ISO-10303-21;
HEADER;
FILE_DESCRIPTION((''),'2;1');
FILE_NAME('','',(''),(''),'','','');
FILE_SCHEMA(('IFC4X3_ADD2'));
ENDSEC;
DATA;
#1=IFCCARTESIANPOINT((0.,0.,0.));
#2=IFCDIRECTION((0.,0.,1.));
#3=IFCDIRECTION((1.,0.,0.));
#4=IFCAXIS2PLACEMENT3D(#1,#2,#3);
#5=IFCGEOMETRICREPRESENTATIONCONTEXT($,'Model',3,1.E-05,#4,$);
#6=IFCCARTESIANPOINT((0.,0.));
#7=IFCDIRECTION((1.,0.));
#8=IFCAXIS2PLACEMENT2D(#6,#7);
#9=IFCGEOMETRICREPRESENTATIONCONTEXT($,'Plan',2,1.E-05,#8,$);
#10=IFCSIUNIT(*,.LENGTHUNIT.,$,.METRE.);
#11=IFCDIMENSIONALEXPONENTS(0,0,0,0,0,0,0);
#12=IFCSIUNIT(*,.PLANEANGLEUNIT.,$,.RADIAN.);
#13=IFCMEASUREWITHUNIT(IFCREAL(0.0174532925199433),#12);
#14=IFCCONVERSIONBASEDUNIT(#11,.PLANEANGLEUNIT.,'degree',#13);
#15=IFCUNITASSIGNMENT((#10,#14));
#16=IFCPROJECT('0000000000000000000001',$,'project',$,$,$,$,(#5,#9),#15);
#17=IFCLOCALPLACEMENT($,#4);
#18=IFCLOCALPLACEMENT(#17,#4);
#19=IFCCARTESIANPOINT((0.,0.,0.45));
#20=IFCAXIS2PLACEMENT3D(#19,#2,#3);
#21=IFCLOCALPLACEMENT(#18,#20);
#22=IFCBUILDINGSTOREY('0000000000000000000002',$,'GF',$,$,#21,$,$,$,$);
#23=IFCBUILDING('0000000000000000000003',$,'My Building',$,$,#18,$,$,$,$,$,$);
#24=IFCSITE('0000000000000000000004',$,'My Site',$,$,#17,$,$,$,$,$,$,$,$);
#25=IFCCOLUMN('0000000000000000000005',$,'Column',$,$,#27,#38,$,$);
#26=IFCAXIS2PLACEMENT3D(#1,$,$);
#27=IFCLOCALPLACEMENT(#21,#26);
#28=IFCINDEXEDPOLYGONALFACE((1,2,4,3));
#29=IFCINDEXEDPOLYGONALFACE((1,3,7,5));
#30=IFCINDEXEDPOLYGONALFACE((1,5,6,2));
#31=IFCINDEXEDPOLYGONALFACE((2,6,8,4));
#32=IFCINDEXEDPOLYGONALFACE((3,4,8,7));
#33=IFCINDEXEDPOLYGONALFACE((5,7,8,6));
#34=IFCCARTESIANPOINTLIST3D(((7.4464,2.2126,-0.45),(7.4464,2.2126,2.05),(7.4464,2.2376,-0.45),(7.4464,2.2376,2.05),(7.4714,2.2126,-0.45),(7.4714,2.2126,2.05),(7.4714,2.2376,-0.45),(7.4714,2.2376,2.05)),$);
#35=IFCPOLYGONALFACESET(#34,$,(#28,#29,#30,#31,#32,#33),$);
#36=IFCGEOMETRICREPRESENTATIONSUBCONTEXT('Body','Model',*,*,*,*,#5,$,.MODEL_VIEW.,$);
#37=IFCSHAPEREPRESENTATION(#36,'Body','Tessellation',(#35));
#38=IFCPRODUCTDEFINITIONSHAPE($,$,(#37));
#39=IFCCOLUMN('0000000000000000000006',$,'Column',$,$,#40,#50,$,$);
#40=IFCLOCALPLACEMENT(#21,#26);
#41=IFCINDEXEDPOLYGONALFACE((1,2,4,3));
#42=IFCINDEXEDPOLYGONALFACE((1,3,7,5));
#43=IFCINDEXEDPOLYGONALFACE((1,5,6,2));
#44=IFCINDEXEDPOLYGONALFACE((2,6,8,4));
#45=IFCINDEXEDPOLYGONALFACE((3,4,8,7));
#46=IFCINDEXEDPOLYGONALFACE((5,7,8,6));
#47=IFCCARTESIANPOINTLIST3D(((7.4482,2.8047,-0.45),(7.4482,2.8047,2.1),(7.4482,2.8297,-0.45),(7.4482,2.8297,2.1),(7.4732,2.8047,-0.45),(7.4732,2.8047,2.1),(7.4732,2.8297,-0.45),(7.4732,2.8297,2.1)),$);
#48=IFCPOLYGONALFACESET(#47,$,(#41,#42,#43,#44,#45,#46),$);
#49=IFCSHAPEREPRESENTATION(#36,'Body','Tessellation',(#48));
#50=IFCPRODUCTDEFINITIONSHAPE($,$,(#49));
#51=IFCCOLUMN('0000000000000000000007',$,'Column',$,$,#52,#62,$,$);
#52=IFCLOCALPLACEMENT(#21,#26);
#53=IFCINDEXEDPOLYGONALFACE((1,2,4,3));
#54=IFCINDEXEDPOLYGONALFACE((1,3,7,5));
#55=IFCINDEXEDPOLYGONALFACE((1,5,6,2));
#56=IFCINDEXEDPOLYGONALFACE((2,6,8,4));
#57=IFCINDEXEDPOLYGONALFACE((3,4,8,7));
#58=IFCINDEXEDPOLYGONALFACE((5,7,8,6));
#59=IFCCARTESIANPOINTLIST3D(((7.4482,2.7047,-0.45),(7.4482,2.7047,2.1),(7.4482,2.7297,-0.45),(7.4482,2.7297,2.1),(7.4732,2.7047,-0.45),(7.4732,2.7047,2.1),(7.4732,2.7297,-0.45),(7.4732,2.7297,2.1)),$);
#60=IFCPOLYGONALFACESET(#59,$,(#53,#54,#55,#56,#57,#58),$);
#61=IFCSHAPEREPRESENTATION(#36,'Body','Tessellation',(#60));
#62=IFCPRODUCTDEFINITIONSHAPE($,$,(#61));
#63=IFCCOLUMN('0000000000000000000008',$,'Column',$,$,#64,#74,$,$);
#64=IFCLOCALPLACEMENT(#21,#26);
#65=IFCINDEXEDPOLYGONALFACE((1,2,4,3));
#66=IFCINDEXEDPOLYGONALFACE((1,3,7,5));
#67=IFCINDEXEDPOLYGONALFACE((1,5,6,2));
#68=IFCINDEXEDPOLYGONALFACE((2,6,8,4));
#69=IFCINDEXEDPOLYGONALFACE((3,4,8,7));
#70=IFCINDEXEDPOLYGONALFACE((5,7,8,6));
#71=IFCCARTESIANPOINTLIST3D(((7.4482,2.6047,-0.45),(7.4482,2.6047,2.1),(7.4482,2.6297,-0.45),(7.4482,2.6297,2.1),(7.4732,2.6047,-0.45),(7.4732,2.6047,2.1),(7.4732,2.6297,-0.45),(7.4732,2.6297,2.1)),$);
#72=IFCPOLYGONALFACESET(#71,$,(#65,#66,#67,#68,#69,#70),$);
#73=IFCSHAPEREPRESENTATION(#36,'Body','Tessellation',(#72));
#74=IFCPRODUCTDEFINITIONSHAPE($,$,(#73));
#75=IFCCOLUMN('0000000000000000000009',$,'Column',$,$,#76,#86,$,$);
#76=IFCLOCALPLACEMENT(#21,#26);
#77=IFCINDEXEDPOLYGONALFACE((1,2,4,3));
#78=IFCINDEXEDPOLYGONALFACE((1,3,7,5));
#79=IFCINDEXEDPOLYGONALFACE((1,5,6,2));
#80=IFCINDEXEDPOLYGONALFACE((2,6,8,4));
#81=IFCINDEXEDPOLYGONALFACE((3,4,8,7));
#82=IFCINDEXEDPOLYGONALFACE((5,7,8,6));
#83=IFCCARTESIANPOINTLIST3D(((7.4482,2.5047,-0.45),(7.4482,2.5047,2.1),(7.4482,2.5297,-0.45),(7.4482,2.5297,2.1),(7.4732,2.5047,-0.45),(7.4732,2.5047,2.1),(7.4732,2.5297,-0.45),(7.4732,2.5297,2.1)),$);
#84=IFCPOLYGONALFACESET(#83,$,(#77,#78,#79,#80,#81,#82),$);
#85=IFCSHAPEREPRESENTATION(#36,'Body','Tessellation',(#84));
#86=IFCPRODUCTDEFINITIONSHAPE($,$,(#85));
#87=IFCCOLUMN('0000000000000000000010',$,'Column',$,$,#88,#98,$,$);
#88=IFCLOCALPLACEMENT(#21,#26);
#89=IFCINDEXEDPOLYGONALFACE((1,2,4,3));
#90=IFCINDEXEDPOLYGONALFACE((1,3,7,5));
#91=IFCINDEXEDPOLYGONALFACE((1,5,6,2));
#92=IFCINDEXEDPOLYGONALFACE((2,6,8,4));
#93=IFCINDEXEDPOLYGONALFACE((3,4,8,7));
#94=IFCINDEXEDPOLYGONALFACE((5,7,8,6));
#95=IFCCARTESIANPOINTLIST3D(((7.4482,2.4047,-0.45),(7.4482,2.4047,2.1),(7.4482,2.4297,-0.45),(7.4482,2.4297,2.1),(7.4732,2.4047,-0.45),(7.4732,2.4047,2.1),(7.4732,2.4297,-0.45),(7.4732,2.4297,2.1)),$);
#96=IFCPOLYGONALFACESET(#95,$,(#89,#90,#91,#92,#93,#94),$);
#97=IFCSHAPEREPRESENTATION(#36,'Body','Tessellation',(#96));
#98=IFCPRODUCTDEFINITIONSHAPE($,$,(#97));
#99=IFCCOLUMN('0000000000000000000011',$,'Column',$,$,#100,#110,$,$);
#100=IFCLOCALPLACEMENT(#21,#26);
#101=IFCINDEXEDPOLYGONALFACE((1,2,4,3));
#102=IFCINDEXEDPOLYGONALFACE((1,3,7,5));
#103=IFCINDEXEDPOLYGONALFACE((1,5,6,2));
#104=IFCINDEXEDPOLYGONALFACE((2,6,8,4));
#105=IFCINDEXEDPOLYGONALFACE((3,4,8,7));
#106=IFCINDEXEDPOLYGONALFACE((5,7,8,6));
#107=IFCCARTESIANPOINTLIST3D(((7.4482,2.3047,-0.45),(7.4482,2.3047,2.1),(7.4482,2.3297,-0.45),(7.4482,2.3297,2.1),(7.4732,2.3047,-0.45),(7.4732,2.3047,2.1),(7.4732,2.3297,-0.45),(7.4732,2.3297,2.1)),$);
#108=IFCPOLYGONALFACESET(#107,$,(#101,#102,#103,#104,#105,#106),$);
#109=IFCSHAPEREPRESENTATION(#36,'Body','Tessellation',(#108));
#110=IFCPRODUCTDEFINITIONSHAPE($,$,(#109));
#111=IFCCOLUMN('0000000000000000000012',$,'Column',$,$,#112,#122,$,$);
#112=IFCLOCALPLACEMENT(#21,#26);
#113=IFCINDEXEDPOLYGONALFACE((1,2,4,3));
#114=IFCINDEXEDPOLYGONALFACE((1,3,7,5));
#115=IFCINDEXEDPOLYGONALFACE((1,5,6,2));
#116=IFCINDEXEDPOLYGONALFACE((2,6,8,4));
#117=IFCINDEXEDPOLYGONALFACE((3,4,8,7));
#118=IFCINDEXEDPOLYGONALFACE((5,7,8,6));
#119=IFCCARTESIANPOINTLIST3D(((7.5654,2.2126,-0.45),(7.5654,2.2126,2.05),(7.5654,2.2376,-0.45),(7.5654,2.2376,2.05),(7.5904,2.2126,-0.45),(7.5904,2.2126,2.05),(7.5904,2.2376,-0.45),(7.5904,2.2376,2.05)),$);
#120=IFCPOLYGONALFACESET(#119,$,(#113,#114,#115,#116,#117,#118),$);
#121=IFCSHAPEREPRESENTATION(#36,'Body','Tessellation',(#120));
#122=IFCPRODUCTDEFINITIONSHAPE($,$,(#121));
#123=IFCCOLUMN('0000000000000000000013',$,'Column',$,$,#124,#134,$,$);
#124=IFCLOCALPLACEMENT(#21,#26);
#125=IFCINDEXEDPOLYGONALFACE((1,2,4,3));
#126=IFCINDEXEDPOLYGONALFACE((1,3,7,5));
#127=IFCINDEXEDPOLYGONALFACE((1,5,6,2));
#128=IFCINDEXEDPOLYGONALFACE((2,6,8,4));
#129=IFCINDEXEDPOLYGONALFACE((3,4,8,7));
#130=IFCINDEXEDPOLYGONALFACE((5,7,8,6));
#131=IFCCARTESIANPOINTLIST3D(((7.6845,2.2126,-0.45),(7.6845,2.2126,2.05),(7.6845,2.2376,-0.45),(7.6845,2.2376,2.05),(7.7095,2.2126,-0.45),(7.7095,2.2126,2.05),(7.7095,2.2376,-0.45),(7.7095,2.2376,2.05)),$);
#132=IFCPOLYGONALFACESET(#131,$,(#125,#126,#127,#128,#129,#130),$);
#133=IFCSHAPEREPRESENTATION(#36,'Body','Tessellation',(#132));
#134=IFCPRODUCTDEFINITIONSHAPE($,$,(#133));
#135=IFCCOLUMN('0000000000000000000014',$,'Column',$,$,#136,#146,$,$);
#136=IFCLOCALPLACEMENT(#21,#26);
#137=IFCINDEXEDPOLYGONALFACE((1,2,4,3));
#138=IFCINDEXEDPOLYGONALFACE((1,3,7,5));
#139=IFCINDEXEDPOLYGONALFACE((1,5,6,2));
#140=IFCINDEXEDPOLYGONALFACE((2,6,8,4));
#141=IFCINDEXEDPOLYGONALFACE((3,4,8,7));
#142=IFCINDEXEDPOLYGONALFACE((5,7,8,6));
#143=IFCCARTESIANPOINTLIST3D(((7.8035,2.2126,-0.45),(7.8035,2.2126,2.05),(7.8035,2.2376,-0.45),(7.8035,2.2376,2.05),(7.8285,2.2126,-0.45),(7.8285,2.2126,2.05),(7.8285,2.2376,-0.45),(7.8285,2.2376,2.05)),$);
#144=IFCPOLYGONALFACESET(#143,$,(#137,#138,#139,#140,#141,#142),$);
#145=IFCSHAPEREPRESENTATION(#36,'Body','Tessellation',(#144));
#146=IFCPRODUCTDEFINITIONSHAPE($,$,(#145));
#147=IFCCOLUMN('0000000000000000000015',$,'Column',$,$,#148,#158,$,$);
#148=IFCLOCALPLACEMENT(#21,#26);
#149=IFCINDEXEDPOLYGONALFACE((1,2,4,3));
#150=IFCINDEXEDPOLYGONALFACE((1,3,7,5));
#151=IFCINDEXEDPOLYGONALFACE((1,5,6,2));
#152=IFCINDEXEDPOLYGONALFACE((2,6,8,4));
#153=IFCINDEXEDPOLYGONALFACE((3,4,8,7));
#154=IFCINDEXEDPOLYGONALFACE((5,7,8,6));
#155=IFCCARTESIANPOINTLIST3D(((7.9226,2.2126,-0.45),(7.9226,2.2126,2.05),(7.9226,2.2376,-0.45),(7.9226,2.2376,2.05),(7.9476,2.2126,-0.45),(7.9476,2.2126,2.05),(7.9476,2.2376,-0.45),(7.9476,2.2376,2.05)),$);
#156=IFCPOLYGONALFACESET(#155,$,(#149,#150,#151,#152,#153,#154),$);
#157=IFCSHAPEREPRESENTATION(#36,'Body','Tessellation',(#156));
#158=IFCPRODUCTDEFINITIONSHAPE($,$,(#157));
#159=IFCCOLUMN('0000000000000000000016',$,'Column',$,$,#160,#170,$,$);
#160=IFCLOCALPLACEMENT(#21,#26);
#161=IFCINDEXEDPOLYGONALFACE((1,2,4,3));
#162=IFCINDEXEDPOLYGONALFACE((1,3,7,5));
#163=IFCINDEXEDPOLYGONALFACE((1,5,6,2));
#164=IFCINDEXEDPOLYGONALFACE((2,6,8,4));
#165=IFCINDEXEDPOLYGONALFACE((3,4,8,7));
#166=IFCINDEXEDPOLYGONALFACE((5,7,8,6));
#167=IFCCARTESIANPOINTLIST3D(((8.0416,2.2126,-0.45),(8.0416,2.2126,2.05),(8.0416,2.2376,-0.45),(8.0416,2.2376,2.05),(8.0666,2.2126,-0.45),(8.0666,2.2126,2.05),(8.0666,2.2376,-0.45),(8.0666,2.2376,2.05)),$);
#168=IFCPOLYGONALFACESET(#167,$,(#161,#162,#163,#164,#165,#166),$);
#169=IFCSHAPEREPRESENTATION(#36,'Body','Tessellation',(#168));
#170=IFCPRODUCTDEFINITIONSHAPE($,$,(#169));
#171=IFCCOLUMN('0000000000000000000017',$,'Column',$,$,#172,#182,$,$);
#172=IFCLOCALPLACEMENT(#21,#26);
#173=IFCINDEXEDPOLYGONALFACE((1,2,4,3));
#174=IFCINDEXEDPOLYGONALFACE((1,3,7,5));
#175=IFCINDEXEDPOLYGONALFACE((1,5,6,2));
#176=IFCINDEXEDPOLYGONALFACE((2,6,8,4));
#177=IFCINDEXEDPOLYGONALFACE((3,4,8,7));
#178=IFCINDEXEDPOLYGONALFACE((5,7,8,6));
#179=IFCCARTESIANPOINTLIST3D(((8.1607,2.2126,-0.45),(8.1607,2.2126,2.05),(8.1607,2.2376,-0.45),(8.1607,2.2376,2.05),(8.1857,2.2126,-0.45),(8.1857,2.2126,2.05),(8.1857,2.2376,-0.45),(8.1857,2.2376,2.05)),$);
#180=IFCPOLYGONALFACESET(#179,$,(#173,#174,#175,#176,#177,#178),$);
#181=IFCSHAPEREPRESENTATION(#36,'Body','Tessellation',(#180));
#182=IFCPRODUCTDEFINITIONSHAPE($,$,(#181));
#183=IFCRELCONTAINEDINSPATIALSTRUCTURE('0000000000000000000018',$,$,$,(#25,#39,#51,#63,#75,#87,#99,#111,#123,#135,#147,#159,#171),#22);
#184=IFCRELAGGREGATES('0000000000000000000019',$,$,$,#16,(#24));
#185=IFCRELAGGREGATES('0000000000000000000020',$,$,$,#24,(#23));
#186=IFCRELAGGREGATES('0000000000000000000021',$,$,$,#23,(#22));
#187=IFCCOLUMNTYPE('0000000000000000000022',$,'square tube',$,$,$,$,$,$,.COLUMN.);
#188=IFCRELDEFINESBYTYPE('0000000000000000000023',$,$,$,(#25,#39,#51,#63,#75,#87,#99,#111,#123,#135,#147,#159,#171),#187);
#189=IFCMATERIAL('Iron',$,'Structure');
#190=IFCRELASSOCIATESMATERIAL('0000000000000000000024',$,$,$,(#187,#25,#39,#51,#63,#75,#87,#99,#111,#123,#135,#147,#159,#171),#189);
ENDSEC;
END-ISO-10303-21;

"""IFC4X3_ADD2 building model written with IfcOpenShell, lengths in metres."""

from ifc_helpers import new_model, entity, si_unit, converted_unit, frame, origin_with_axes, origin_2d_with_axis, place, context, subcontext, project, spatial, indexed_curve, outline, extrude, material, material_profile, profile_set, profile_usage, type_object, element, save


model = new_model("IFC4X3_ADD2")

# Units and contexts
model_context = context("Model", 3, precision=1e-05, world=origin_with_axes())
plan_context = context("Plan", 2, precision=1e-05, world=origin_2d_with_axis())
body_context = subcontext(model_context, "Body", "Model", "MODEL_VIEW")
ifc_project = project(units=[si_unit("LENGTHUNIT", "METRE"), converted_unit("PLANEANGLEUNIT", "degree", entity("IfcReal", 0.0174532925199433), si_unit("PLANEANGLEUNIT", "RADIAN"), dimensions=[0, 0, 0, 0, 0, 0, 0])], contexts=[model_context, plan_context])

# Site, building, storey
site_placement = place(None, origin_with_axes())
site = spatial("IfcSite", under=ifc_project, at=site_placement, Name="My Site")
building_placement = place(site_placement, origin_with_axes())
building = spatial("IfcBuilding", under=site, at=building_placement, Name="My Building")
storey_placement = place(building_placement, frame((0.0, 0.0, 0.45), z_axis=(0.0, 0.0, 1.0), x_axis=(1.0, 0.0, 0.0)))
storey = spatial("IfcBuildingStorey", under=building, at=storey_placement, Name="GF")

# Columns
ifc_material_1 = material(Name="Iron", Category="Structure")
ifc_material_profile = material_profile(ifc_material_1, outline(indexed_curve([(-0.0125, -0.0125), (0.0125, -0.0125), (0.0125, 0.0125), (-0.0125, 0.0125), (-0.0125, -0.0125)])))
ifc_profile_set = profile_set([ifc_material_profile])
ifc_profile_usage_1 = profile_usage(ifc_profile_set, cardinal=5)
column_type = type_object("IfcColumnType", Name="square tube", PredefinedType="COLUMN", material=ifc_profile_set)
column_1_placement = place(storey_placement, frame((7.4589, 2.2251, -0.45), z_axis=(0.0, 0.0, 1.0), x_axis=(1.0, 0.0, 0.0)))
element("IfcColumn", 1, at=column_1_placement, inside=storey, type_object=column_type, material=ifc_profile_usage_1, Name="Column", context=body_context, shape_type="SweptSolid", body=[
    extrude(outline(indexed_curve([(-0.0125, -0.0125), (0.0125, -0.0125), (0.0125, 0.0125), (-0.0125, 0.0125), (-0.0125, -0.0125)])), origin_with_axes(), (0.0, 0.0, 1.0), 2.5),
])
ifc_profile_usage_2 = profile_usage(ifc_profile_set, cardinal=5)
column_2_placement = place(storey_placement, frame((7.4607, 2.8172, -0.45), z_axis=(0.0, 0.0, 1.0), x_axis=(0.0, -1.0, 0.0)))
element("IfcColumn", 2, at=column_2_placement, inside=storey, type_object=column_type, material=ifc_profile_usage_2, Name="Column", context=body_context, shape_type="SweptSolid", body=[
    extrude(outline(indexed_curve([(-0.0125, -0.0125), (0.0125, -0.0125), (0.0125, 0.0125), (-0.0125, 0.0125), (-0.0125, -0.0125)])), origin_with_axes(), (0.0, 0.0, 1.0), 2.55),
])
ifc_profile_usage_3 = profile_usage(ifc_profile_set, cardinal=5)
column_3_placement = place(storey_placement, frame((7.4607, 2.7172, -0.45), z_axis=(0.0, 0.0, 1.0), x_axis=(0.0, -1.0, 0.0)))
element("IfcColumn", 3, at=column_3_placement, inside=storey, type_object=column_type, material=ifc_profile_usage_3, Name="Column", context=body_context, shape_type="SweptSolid", body=[
    extrude(outline(indexed_curve([(-0.0125, -0.0125), (0.0125, -0.0125), (0.0125, 0.0125), (-0.0125, 0.0125), (-0.0125, -0.0125)])), origin_with_axes(), (0.0, 0.0, 1.0), 2.55),
])
ifc_profile_usage_4 = profile_usage(ifc_profile_set, cardinal=5)
column_4_placement = place(storey_placement, frame((7.4607, 2.6172, -0.45), z_axis=(0.0, 0.0, 1.0), x_axis=(0.0, -1.0, 0.0)))
element("IfcColumn", 4, at=column_4_placement, inside=storey, type_object=column_type, material=ifc_profile_usage_4, Name="Column", context=body_context, shape_type="SweptSolid", body=[
    extrude(outline(indexed_curve([(-0.0125, -0.0125), (0.0125, -0.0125), (0.0125, 0.0125), (-0.0125, 0.0125), (-0.0125, -0.0125)])), origin_with_axes(), (0.0, 0.0, 1.0), 2.55),
])
ifc_profile_usage_5 = profile_usage(ifc_profile_set, cardinal=5)
column_5_placement = place(storey_placement, frame((7.4607, 2.5172, -0.45), z_axis=(0.0, 0.0, 1.0), x_axis=(0.0, -1.0, 0.0)))
element("IfcColumn", 5, at=column_5_placement, inside=storey, type_object=column_type, material=ifc_profile_usage_5, Name="Column", context=body_context, shape_type="SweptSolid", body=[
    extrude(outline(indexed_curve([(-0.0125, -0.0125), (0.0125, -0.0125), (0.0125, 0.0125), (-0.0125, 0.0125), (-0.0125, -0.0125)])), origin_with_axes(), (0.0, 0.0, 1.0), 2.55),
])
ifc_profile_usage_6 = profile_usage(ifc_profile_set, cardinal=5)
column_6_placement = place(storey_placement, frame((7.4607, 2.4172, -0.45), z_axis=(0.0, 0.0, 1.0), x_axis=(0.0, -1.0, 0.0)))
element("IfcColumn", 6, at=column_6_placement, inside=storey, type_object=column_type, material=ifc_profile_usage_6, Name="Column", context=body_context, shape_type="SweptSolid", body=[
    extrude(outline(indexed_curve([(-0.0125, -0.0125), (0.0125, -0.0125), (0.0125, 0.0125), (-0.0125, 0.0125), (-0.0125, -0.0125)])), origin_with_axes(), (0.0, 0.0, 1.0), 2.55),
])
ifc_profile_usage_7 = profile_usage(ifc_profile_set, cardinal=5)
column_7_placement = place(storey_placement, frame((7.4607, 2.3172, -0.45), z_axis=(0.0, 0.0, 1.0), x_axis=(0.0, -1.0, 0.0)))
element("IfcColumn", 7, at=column_7_placement, inside=storey, type_object=column_type, material=ifc_profile_usage_7, Name="Column", context=body_context, shape_type="SweptSolid", body=[
    extrude(outline(indexed_curve([(-0.0125, -0.0125), (0.0125, -0.0125), (0.0125, 0.0125), (-0.0125, 0.0125), (-0.0125, -0.0125)])), origin_with_axes(), (0.0, 0.0, 1.0), 2.55),
])
ifc_profile_usage_8 = profile_usage(ifc_profile_set, cardinal=5)
column_8_placement = place(storey_placement, frame((7.5779, 2.2251, -0.45), z_axis=(0.0, 0.0, 1.0), x_axis=(1.0, 0.0, 0.0)))
element("IfcColumn", 8, at=column_8_placement, inside=storey, type_object=column_type, material=ifc_profile_usage_8, Name="Column", context=body_context, shape_type="SweptSolid", body=[
    extrude(outline(indexed_curve([(-0.0125, -0.0125), (0.0125, -0.0125), (0.0125, 0.0125), (-0.0125, 0.0125), (-0.0125, -0.0125)])), origin_with_axes(), (0.0, 0.0, 1.0), 2.5),
])
ifc_profile_usage_9 = profile_usage(ifc_profile_set, cardinal=5)
column_9_placement = place(storey_placement, frame((7.697, 2.2251, -0.45), z_axis=(0.0, 0.0, 1.0), x_axis=(1.0, 0.0, 0.0)))
element("IfcColumn", 9, at=column_9_placement, inside=storey, type_object=column_type, material=ifc_profile_usage_9, Name="Column", context=body_context, shape_type="SweptSolid", body=[
    extrude(outline(indexed_curve([(-0.0125, -0.0125), (0.0125, -0.0125), (0.0125, 0.0125), (-0.0125, 0.0125), (-0.0125, -0.0125)])), origin_with_axes(), (0.0, 0.0, 1.0), 2.5),
])
ifc_profile_usage_10 = profile_usage(ifc_profile_set, cardinal=5)
column_10_placement = place(storey_placement, frame((7.816, 2.2251, -0.45), z_axis=(0.0, 0.0, 1.0), x_axis=(1.0, 0.0, 0.0)))
element("IfcColumn", 10, at=column_10_placement, inside=storey, type_object=column_type, material=ifc_profile_usage_10, Name="Column", context=body_context, shape_type="SweptSolid", body=[
    extrude(outline(indexed_curve([(-0.0125, -0.0125), (0.0125, -0.0125), (0.0125, 0.0125), (-0.0125, 0.0125), (-0.0125, -0.0125)])), origin_with_axes(), (0.0, 0.0, 1.0), 2.5),
])
ifc_profile_usage_11 = profile_usage(ifc_profile_set, cardinal=5)
column_11_placement = place(storey_placement, frame((7.9351, 2.2251, -0.45), z_axis=(0.0, 0.0, 1.0), x_axis=(1.0, 0.0, 0.0)))
element("IfcColumn", 11, at=column_11_placement, inside=storey, type_object=column_type, material=ifc_profile_usage_11, Name="Column", context=body_context, shape_type="SweptSolid", body=[
    extrude(outline(indexed_curve([(-0.0125, -0.0125), (0.0125, -0.0125), (0.0125, 0.0125), (-0.0125, 0.0125), (-0.0125, -0.0125)])), origin_with_axes(), (0.0, 0.0, 1.0), 2.5),
])
ifc_profile_usage_12 = profile_usage(ifc_profile_set, cardinal=5)
column_12_placement = place(storey_placement, frame((8.0541, 2.2251, -0.45), z_axis=(0.0, 0.0, 1.0), x_axis=(1.0, 0.0, 0.0)))
element("IfcColumn", 12, at=column_12_placement, inside=storey, type_object=column_type, material=ifc_profile_usage_12, Name="Column", context=body_context, shape_type="SweptSolid", body=[
    extrude(outline(indexed_curve([(-0.0125, -0.0125), (0.0125, -0.0125), (0.0125, 0.0125), (-0.0125, 0.0125), (-0.0125, -0.0125)])), origin_with_axes(), (0.0, 0.0, 1.0), 2.5),
])
ifc_profile_usage_13 = profile_usage(ifc_profile_set, cardinal=5)
column_13_placement = place(storey_placement, frame((8.1732, 2.2251, -0.45), z_axis=(0.0, 0.0, 1.0), x_axis=(1.0, 0.0, 0.0)))
element("IfcColumn", 13, at=column_13_placement, inside=storey, type_object=column_type, material=ifc_profile_usage_13, Name="Column", context=body_context, shape_type="SweptSolid", body=[
    extrude(outline(indexed_curve([(-0.0125, -0.0125), (0.0125, -0.0125), (0.0125, 0.0125), (-0.0125, 0.0125), (-0.0125, -0.0125)])), origin_with_axes(), (0.0, 0.0, 1.0), 2.5),
])

save(model, "model.ifc")
